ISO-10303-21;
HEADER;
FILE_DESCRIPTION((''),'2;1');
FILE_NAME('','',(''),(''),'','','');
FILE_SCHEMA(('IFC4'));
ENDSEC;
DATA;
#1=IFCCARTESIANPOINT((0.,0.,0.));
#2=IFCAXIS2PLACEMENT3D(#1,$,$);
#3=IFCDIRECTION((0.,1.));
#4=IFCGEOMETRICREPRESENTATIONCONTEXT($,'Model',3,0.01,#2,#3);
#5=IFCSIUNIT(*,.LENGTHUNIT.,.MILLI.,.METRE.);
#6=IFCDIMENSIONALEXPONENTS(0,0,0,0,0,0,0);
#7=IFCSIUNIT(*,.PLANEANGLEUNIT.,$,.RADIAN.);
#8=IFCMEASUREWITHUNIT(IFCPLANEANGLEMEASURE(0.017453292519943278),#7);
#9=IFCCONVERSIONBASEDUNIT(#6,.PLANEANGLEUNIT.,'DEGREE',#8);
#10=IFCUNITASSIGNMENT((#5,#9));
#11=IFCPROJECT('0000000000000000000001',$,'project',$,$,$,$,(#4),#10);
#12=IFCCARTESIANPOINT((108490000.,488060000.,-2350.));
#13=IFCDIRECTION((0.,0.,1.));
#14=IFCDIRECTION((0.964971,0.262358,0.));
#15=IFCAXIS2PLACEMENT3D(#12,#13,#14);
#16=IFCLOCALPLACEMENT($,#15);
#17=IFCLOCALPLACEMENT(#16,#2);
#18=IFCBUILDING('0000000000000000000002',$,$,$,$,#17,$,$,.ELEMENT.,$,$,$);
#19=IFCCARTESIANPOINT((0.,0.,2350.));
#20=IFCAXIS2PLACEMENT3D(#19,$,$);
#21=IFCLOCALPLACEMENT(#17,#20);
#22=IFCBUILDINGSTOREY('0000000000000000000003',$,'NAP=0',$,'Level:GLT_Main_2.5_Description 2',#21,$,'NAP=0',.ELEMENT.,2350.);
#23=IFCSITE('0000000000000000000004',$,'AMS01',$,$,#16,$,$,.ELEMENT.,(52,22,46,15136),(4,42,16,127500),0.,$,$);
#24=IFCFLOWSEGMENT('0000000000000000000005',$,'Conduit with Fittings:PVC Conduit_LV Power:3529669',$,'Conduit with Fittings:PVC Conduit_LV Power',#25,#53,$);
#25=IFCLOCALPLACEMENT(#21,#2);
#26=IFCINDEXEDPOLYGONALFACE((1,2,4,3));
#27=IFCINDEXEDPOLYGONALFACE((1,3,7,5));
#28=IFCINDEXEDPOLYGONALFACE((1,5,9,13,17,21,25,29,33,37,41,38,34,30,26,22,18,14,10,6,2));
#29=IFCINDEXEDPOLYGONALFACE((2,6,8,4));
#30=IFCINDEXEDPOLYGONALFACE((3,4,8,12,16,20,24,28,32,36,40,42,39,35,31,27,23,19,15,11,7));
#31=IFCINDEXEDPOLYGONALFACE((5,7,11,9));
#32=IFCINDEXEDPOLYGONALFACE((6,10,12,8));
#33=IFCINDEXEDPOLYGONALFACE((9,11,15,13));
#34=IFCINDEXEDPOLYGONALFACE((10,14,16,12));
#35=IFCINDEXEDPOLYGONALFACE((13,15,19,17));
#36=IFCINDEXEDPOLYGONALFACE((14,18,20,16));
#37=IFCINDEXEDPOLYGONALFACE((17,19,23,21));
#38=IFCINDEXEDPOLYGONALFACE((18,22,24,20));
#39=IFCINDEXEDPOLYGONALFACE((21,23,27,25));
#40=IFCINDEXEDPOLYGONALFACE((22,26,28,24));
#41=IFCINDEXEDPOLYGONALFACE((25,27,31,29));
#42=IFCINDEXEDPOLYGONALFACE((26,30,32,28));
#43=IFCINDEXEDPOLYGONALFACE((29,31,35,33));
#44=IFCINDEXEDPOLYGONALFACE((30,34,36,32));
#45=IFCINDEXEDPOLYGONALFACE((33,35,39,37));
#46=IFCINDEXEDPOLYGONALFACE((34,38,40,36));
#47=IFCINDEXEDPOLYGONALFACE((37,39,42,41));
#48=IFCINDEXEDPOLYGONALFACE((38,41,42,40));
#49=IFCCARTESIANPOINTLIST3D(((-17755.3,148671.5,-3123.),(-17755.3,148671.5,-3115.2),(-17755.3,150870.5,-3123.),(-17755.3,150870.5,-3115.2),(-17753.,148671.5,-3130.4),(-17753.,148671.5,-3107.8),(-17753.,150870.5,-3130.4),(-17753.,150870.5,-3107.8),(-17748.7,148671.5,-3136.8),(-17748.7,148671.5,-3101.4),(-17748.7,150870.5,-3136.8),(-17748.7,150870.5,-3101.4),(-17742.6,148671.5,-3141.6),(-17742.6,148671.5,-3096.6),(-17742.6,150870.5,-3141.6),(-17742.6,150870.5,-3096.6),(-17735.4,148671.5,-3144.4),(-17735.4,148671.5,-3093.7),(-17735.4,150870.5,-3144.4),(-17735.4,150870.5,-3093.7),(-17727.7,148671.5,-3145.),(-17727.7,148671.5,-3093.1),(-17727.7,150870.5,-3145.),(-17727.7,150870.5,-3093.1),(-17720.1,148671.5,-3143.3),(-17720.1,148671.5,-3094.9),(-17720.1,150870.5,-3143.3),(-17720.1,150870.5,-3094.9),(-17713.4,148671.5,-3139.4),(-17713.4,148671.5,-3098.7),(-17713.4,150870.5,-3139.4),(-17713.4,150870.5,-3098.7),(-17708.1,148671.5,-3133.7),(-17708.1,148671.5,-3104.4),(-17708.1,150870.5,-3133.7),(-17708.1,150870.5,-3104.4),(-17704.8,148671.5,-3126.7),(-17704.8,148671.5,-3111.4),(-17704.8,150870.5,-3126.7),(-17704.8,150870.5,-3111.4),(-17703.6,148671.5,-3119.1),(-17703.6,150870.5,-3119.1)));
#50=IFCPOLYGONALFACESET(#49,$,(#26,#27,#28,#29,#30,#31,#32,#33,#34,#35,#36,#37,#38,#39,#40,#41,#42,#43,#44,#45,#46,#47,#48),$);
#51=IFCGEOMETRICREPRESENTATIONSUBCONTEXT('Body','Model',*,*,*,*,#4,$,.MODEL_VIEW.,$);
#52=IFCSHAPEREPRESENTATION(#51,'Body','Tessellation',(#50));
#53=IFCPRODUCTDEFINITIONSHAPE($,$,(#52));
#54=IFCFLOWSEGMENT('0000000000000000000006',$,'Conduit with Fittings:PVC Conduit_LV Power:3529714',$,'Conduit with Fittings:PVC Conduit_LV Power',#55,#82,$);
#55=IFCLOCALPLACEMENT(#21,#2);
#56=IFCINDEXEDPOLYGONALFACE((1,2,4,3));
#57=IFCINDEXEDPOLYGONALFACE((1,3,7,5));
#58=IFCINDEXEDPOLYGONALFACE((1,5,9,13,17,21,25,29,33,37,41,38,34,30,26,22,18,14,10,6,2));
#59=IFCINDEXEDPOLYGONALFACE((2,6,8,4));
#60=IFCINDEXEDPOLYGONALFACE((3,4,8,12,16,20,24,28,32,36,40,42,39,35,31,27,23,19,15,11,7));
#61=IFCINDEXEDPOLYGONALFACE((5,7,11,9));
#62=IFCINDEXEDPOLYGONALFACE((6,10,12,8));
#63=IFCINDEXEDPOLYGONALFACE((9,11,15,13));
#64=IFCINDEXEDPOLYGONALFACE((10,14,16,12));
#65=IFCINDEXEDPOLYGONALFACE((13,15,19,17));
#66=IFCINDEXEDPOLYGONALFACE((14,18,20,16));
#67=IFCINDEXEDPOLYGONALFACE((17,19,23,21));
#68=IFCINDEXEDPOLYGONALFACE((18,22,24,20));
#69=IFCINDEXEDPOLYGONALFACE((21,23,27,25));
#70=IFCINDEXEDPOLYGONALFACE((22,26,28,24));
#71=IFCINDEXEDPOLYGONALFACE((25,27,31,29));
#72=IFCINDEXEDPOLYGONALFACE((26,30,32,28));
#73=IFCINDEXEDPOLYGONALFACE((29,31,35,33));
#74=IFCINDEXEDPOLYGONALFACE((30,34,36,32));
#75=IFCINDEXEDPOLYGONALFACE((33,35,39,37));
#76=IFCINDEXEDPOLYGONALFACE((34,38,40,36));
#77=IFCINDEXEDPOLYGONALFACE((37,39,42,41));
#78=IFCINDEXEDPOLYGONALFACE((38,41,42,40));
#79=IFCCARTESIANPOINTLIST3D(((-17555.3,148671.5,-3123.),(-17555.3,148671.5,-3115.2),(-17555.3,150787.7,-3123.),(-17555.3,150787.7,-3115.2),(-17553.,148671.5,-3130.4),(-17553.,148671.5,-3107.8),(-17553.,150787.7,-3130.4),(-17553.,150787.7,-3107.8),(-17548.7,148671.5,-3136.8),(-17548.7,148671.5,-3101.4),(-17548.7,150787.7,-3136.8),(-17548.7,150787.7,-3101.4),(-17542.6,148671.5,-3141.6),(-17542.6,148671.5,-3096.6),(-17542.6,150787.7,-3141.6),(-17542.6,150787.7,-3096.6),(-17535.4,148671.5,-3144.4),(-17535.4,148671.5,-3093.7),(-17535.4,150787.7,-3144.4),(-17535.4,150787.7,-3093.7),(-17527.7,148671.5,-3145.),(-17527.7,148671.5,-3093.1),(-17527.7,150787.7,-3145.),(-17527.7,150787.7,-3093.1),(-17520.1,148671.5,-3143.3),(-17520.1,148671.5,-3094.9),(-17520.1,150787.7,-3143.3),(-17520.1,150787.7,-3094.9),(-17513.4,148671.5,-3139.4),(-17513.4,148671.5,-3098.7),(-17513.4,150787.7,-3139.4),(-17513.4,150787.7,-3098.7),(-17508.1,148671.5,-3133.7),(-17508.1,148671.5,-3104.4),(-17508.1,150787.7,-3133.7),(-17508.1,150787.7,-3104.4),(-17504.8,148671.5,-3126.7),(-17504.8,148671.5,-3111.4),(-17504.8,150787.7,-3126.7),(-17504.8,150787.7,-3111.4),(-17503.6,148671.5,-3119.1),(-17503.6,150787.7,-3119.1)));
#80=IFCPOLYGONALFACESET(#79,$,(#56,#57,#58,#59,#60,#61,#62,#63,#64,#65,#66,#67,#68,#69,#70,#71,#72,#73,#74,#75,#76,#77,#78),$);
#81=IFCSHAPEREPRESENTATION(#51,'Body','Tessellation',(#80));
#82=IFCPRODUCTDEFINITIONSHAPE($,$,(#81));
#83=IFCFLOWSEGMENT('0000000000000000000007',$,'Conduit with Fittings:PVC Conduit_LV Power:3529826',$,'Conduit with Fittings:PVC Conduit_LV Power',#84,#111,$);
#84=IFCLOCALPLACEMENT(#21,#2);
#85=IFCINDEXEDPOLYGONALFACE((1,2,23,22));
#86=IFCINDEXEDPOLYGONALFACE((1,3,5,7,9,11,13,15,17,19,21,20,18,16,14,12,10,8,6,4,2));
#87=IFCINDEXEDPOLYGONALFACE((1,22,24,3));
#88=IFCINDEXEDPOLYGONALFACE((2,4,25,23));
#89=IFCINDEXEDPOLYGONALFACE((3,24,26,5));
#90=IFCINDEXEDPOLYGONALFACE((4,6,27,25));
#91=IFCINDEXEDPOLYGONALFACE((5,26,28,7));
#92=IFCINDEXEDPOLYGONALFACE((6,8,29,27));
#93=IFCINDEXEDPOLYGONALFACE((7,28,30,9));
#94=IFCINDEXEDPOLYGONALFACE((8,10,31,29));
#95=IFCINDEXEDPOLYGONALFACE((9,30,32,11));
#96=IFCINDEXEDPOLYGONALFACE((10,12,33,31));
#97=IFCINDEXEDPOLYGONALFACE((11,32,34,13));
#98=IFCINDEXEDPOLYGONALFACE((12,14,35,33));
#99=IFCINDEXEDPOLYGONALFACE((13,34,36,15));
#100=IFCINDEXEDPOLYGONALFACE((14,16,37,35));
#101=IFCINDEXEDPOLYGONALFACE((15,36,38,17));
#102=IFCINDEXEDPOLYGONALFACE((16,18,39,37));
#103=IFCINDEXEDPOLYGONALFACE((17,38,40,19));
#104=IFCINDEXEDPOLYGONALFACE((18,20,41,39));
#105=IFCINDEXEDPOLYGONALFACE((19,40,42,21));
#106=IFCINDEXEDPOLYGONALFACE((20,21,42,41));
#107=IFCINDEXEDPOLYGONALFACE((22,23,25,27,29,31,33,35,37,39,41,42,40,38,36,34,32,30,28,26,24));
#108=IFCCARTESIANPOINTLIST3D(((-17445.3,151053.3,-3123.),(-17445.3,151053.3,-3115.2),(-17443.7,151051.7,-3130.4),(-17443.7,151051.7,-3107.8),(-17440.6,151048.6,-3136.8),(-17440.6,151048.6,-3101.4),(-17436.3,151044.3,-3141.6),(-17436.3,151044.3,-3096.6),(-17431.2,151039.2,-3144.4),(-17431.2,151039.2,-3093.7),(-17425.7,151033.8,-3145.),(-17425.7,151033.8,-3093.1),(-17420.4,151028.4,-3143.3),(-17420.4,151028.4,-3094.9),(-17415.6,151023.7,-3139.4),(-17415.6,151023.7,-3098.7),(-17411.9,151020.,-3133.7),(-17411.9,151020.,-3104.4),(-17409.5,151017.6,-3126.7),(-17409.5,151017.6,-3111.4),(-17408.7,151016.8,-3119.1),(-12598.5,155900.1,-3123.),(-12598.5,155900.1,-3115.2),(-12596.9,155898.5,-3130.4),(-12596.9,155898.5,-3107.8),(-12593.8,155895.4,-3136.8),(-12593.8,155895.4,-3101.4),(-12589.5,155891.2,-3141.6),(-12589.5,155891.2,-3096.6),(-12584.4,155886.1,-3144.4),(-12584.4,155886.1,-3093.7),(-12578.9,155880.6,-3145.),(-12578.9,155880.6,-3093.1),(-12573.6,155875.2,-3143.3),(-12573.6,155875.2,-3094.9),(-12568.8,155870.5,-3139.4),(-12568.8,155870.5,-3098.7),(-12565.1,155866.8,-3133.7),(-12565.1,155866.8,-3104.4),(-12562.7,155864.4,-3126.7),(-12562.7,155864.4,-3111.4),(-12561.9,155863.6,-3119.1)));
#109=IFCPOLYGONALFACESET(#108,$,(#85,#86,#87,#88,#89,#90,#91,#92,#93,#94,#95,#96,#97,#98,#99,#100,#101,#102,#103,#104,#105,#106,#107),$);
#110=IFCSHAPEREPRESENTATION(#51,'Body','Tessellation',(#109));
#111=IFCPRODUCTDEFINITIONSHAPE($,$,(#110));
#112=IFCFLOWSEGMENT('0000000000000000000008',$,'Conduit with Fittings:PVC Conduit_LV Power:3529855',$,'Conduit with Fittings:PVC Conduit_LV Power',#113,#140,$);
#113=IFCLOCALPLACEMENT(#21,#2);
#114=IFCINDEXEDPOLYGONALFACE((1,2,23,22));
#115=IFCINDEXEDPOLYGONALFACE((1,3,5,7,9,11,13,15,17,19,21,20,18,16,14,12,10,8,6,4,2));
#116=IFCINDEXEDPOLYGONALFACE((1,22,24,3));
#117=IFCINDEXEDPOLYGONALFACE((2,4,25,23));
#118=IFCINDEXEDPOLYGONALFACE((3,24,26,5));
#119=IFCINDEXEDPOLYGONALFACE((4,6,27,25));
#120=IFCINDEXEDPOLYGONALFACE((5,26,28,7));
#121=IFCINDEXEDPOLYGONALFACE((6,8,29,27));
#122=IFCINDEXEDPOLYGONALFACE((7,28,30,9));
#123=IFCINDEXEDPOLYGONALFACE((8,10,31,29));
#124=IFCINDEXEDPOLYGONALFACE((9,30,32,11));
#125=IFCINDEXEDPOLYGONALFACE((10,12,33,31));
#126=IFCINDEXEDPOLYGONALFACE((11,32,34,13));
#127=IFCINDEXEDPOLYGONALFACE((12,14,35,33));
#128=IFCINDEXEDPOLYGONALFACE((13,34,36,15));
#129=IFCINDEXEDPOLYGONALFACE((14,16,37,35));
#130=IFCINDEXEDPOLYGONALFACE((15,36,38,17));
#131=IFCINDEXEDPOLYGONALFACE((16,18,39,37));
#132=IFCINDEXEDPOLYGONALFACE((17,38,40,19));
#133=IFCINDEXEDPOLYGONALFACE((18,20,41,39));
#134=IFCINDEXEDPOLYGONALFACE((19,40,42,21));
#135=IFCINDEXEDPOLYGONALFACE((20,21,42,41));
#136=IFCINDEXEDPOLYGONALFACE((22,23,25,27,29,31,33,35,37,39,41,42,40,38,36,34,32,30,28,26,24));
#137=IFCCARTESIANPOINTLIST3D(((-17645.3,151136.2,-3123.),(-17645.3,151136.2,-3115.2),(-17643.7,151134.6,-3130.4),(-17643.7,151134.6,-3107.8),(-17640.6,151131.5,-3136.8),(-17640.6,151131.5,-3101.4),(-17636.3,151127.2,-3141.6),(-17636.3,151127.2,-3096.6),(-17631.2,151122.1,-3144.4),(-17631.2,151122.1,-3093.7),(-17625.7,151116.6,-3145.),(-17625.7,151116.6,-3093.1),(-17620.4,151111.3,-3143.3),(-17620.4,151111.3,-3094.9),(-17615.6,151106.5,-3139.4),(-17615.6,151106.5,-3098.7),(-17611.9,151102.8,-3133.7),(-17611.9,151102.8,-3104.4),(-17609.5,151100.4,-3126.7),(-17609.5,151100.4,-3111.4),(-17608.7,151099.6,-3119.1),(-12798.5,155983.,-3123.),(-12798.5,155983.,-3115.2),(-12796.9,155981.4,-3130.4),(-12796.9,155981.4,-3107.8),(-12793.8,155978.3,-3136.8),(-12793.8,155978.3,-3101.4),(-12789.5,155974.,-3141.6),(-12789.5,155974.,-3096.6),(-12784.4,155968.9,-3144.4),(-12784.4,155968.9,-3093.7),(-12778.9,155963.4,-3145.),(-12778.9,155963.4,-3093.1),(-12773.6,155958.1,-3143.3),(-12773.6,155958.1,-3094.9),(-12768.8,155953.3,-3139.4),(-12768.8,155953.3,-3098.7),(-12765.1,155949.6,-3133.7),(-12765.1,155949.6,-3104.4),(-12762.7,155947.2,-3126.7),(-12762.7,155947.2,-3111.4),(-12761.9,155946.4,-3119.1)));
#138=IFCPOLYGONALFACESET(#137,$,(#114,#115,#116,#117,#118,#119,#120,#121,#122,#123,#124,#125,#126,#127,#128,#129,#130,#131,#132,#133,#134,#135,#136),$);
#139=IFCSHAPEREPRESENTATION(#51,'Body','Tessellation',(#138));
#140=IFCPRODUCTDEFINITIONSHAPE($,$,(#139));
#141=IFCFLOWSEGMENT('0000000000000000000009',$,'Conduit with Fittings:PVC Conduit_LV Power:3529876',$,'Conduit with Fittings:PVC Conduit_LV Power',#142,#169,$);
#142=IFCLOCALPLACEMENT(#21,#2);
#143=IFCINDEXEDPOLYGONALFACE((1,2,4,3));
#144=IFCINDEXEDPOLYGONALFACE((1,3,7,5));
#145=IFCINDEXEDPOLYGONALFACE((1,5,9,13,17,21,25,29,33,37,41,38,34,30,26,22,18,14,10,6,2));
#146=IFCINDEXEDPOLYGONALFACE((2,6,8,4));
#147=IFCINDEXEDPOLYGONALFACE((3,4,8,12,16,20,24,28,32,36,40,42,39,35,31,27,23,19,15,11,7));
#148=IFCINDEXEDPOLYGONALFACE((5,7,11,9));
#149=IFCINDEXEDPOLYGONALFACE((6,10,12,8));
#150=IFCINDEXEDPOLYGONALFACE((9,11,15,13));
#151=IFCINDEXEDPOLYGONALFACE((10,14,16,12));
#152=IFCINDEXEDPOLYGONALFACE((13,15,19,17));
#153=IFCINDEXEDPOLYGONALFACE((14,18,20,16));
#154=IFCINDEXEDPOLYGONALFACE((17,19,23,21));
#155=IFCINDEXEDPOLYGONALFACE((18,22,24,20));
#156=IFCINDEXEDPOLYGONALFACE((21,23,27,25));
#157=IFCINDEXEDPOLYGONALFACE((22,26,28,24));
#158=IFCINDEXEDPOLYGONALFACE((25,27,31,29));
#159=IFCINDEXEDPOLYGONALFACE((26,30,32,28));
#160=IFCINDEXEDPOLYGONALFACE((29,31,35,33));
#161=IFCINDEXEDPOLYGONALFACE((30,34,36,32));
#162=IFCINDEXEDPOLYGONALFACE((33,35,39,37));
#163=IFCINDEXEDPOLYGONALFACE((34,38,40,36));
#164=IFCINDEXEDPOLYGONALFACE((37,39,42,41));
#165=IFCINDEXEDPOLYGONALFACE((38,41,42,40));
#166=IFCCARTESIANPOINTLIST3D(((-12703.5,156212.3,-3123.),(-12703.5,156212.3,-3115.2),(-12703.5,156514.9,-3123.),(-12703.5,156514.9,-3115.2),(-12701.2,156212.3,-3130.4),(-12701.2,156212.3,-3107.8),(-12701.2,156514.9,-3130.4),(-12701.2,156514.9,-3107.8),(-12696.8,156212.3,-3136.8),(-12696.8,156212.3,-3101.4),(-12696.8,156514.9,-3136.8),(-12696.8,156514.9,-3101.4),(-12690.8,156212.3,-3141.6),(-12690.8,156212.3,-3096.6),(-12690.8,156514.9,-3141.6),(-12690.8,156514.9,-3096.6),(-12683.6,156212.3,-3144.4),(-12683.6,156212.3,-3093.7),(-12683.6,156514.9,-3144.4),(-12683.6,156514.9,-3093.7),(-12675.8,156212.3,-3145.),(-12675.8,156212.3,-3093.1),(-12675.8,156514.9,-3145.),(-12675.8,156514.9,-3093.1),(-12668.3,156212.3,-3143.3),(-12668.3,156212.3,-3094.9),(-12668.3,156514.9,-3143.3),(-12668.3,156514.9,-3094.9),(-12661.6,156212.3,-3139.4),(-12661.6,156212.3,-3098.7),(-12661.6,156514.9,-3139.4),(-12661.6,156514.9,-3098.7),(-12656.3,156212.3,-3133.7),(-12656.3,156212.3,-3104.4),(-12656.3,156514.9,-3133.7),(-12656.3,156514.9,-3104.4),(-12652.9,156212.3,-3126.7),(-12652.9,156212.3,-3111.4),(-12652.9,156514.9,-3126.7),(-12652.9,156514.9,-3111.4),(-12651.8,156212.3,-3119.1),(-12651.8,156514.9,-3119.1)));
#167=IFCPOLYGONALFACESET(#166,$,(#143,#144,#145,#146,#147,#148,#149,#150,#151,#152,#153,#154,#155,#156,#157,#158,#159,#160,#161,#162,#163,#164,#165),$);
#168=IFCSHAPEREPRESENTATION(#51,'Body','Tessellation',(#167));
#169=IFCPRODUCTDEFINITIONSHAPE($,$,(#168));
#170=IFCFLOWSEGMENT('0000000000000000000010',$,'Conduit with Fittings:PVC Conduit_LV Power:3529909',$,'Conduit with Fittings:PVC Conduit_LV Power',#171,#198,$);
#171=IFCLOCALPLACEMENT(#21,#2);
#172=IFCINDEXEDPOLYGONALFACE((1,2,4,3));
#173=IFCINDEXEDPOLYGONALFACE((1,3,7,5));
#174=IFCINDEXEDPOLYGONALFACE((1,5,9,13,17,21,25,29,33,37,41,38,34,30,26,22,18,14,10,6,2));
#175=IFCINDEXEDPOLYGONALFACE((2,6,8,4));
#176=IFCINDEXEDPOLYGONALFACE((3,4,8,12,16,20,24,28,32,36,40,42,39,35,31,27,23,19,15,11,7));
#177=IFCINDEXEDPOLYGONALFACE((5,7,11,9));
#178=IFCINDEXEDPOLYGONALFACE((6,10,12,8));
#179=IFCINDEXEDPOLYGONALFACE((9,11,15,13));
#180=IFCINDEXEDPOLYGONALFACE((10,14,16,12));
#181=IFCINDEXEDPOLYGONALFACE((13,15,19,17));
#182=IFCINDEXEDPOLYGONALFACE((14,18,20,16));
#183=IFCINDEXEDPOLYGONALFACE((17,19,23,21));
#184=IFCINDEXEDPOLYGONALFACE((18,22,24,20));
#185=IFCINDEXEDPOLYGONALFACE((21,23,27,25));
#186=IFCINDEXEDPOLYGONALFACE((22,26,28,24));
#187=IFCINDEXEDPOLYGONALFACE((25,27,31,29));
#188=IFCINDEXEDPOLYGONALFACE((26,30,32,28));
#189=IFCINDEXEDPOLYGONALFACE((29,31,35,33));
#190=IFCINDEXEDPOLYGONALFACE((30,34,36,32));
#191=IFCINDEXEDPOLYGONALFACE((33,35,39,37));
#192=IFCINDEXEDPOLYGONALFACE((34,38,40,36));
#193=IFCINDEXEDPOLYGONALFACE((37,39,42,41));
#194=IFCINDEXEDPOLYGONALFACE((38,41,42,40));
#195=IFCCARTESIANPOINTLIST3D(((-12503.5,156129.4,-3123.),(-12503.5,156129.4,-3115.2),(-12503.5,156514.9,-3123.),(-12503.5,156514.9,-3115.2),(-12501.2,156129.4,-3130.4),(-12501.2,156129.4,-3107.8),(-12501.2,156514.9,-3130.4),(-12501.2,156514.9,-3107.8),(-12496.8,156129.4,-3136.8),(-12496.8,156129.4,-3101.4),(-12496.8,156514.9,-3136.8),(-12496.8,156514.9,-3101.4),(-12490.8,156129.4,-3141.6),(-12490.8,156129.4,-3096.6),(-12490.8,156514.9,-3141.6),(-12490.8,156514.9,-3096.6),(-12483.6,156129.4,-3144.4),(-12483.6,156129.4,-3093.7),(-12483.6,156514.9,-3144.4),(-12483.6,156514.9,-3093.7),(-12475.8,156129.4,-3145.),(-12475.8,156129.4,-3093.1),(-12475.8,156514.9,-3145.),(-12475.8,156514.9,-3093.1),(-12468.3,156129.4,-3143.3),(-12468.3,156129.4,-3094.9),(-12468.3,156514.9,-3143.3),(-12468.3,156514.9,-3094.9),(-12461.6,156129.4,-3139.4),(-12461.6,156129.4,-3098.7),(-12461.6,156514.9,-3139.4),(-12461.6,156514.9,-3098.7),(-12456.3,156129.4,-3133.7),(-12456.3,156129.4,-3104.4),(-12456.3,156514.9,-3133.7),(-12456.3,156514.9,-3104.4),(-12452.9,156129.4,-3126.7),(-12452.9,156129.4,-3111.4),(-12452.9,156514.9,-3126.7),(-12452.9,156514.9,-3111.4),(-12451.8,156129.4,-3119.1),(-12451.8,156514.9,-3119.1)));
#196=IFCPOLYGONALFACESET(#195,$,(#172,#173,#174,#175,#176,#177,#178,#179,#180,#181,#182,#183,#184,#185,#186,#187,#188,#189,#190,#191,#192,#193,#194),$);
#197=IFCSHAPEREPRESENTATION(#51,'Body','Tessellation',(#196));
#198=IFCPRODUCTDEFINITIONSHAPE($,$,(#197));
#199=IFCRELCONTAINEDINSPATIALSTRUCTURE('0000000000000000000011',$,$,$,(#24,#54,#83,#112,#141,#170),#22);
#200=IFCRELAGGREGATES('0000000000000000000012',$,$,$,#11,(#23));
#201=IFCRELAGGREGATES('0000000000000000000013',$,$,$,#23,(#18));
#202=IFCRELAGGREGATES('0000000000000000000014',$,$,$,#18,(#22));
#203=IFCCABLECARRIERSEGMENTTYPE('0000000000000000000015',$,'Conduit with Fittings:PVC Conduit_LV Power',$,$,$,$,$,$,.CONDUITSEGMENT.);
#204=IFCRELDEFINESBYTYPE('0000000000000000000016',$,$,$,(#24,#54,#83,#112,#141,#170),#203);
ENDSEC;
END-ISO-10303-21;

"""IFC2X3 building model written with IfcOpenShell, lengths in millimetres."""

from ifc_helpers import new_model, entity, si_unit, converted_unit, direction, frame, frame_2d, origin, origin_2d_with_axis, place, context, subcontext, project, spatial, circle, extrude, type_object, element, save


model = new_model("IFC2X3")

# Units and contexts
model_context = context("Model", 3, precision=0.01, world=origin(), true_north=direction((0.0, 1.0)))
body_context = subcontext(model_context, "Body", "Model", "MODEL_VIEW")
ifc_project = project(units=[si_unit("LENGTHUNIT", "METRE", prefix="MILLI"), converted_unit("PLANEANGLEUNIT", "DEGREE", entity("IfcPlaneAngleMeasure", 0.017453292519943278), si_unit("PLANEANGLEUNIT", "RADIAN"), dimensions=[0, 0, 0, 0, 0, 0, 0])], contexts=[model_context])

# Site, building, storey
site_placement = place(None, frame((108490000.0, 488060000.0, -2350.0), z_axis=(0.0, 0.0, 1.0), x_axis=(0.964971, 0.262358, 0.0)))
site = spatial("IfcSite", under=ifc_project, at=site_placement, Name="AMS01", CompositionType="ELEMENT", RefLatitude=(52, 22, 46, 15136), RefLongitude=(4, 42, 16, 127500), RefElevation=0.0)
building_placement = place(site_placement, origin())
building = spatial("IfcBuilding", under=site, at=building_placement, CompositionType="ELEMENT")
storey_placement = place(building_placement, frame((0.0, 0.0, 2350.0)))
storey = spatial("IfcBuildingStorey", under=building, at=storey_placement, Name="NAP=0", ObjectType="Level:GLT_Main_2.5_Description 2", LongName="NAP=0", CompositionType="ELEMENT", Elevation=2350.0)

# Flow segments
cable_carrier_segment_type = type_object("IfcCableCarrierSegmentType", Name="Conduit with Fittings:PVC Conduit_LV Power", PredefinedType="CONDUITSEGMENT")
flow_segment_1_placement = place(storey_placement, origin())
element("IfcFlowSegment", 1, at=flow_segment_1_placement, inside=storey, type_object=cable_carrier_segment_type, Name="Conduit with Fittings:PVC Conduit_LV Power:3529669", ObjectType="Conduit with Fittings:PVC Conduit_LV Power", context=body_context, shape_type="SweptSolid", body=[
    extrude(circle(Radius=26.0, at=frame_2d((0.0, 0.0), x_axis=(1.0, 0.0))), frame((-17729.6, 148671.5, -3119.1), z_axis=(0.0, 1.0, 0.0), x_axis=(1.0, 0.0, 0.0)), (0.0, 0.0, 1.0), 2199.0),
])
flow_segment_2_placement = place(storey_placement, origin())
element("IfcFlowSegment", 2, at=flow_segment_2_placement, inside=storey, type_object=cable_carrier_segment_type, Name="Conduit with Fittings:PVC Conduit_LV Power:3529714", ObjectType="Conduit with Fittings:PVC Conduit_LV Power", context=body_context, shape_type="SweptSolid", body=[
    extrude(circle(Radius=26.0, at=origin_2d_with_axis()), frame((-17529.6, 148671.5, -3119.1), z_axis=(0.0, 1.0, 0.0), x_axis=(1.0, 0.0, 0.0)), (0.0, 0.0, 1.0), 2116.1),
])
flow_segment_3_placement = place(storey_placement, origin())
element("IfcFlowSegment", 3, at=flow_segment_3_placement, inside=storey, type_object=cable_carrier_segment_type, Name="Conduit with Fittings:PVC Conduit_LV Power:3529826", ObjectType="Conduit with Fittings:PVC Conduit_LV Power", context=body_context, shape_type="SweptSolid", body=[
    extrude(circle(Radius=26.0, at=frame_2d((0.0, 0.0), x_axis=(1.0, 0.0))), frame((-17427.1, 151035.1, -3119.1), z_axis=(0.707107, 0.707107, 0.0), x_axis=(0.707107, -0.707107, 0.0)), (0.0, 0.0, 1.0), 6854.4),
])
flow_segment_4_placement = place(storey_placement, origin())
element("IfcFlowSegment", 4, at=flow_segment_4_placement, inside=storey, type_object=cable_carrier_segment_type, Name="Conduit with Fittings:PVC Conduit_LV Power:3529855", ObjectType="Conduit with Fittings:PVC Conduit_LV Power", context=body_context, shape_type="SweptSolid", body=[
    extrude(circle(Radius=26.0, at=origin_2d_with_axis()), frame((-17627.1, 151118.0, -3119.1), z_axis=(0.707107, 0.707107, 0.0), x_axis=(0.707107, -0.707107, 0.0)), (0.0, 0.0, 1.0), 6854.4),
])
flow_segment_5_placement = place(storey_placement, origin())
element("IfcFlowSegment", 5, at=flow_segment_5_placement, inside=storey, type_object=cable_carrier_segment_type, Name="Conduit with Fittings:PVC Conduit_LV Power:3529876", ObjectType="Conduit with Fittings:PVC Conduit_LV Power", context=body_context, shape_type="SweptSolid", body=[
    extrude(circle(Radius=26.0, at=origin_2d_with_axis()), frame((-12677.8, 156212.3, -3119.1), z_axis=(0.0, 1.0, 0.0), x_axis=(1.0, 0.0, 0.0)), (0.0, 0.0, 1.0), 302.6),
])
flow_segment_6_placement = place(storey_placement, origin())
element("IfcFlowSegment", 6, at=flow_segment_6_placement, inside=storey, type_object=cable_carrier_segment_type, Name="Conduit with Fittings:PVC Conduit_LV Power:3529909", ObjectType="Conduit with Fittings:PVC Conduit_LV Power", context=body_context, shape_type="SweptSolid", body=[
    extrude(circle(Radius=26.0, at=origin_2d_with_axis()), frame((-12477.8, 156129.4, -3119.1), z_axis=(0.0, 1.0, 0.0), x_axis=(1.0, 0.0, 0.0)), (0.0, 0.0, 1.0), 385.4),
])

save(model, "model.ifc")
